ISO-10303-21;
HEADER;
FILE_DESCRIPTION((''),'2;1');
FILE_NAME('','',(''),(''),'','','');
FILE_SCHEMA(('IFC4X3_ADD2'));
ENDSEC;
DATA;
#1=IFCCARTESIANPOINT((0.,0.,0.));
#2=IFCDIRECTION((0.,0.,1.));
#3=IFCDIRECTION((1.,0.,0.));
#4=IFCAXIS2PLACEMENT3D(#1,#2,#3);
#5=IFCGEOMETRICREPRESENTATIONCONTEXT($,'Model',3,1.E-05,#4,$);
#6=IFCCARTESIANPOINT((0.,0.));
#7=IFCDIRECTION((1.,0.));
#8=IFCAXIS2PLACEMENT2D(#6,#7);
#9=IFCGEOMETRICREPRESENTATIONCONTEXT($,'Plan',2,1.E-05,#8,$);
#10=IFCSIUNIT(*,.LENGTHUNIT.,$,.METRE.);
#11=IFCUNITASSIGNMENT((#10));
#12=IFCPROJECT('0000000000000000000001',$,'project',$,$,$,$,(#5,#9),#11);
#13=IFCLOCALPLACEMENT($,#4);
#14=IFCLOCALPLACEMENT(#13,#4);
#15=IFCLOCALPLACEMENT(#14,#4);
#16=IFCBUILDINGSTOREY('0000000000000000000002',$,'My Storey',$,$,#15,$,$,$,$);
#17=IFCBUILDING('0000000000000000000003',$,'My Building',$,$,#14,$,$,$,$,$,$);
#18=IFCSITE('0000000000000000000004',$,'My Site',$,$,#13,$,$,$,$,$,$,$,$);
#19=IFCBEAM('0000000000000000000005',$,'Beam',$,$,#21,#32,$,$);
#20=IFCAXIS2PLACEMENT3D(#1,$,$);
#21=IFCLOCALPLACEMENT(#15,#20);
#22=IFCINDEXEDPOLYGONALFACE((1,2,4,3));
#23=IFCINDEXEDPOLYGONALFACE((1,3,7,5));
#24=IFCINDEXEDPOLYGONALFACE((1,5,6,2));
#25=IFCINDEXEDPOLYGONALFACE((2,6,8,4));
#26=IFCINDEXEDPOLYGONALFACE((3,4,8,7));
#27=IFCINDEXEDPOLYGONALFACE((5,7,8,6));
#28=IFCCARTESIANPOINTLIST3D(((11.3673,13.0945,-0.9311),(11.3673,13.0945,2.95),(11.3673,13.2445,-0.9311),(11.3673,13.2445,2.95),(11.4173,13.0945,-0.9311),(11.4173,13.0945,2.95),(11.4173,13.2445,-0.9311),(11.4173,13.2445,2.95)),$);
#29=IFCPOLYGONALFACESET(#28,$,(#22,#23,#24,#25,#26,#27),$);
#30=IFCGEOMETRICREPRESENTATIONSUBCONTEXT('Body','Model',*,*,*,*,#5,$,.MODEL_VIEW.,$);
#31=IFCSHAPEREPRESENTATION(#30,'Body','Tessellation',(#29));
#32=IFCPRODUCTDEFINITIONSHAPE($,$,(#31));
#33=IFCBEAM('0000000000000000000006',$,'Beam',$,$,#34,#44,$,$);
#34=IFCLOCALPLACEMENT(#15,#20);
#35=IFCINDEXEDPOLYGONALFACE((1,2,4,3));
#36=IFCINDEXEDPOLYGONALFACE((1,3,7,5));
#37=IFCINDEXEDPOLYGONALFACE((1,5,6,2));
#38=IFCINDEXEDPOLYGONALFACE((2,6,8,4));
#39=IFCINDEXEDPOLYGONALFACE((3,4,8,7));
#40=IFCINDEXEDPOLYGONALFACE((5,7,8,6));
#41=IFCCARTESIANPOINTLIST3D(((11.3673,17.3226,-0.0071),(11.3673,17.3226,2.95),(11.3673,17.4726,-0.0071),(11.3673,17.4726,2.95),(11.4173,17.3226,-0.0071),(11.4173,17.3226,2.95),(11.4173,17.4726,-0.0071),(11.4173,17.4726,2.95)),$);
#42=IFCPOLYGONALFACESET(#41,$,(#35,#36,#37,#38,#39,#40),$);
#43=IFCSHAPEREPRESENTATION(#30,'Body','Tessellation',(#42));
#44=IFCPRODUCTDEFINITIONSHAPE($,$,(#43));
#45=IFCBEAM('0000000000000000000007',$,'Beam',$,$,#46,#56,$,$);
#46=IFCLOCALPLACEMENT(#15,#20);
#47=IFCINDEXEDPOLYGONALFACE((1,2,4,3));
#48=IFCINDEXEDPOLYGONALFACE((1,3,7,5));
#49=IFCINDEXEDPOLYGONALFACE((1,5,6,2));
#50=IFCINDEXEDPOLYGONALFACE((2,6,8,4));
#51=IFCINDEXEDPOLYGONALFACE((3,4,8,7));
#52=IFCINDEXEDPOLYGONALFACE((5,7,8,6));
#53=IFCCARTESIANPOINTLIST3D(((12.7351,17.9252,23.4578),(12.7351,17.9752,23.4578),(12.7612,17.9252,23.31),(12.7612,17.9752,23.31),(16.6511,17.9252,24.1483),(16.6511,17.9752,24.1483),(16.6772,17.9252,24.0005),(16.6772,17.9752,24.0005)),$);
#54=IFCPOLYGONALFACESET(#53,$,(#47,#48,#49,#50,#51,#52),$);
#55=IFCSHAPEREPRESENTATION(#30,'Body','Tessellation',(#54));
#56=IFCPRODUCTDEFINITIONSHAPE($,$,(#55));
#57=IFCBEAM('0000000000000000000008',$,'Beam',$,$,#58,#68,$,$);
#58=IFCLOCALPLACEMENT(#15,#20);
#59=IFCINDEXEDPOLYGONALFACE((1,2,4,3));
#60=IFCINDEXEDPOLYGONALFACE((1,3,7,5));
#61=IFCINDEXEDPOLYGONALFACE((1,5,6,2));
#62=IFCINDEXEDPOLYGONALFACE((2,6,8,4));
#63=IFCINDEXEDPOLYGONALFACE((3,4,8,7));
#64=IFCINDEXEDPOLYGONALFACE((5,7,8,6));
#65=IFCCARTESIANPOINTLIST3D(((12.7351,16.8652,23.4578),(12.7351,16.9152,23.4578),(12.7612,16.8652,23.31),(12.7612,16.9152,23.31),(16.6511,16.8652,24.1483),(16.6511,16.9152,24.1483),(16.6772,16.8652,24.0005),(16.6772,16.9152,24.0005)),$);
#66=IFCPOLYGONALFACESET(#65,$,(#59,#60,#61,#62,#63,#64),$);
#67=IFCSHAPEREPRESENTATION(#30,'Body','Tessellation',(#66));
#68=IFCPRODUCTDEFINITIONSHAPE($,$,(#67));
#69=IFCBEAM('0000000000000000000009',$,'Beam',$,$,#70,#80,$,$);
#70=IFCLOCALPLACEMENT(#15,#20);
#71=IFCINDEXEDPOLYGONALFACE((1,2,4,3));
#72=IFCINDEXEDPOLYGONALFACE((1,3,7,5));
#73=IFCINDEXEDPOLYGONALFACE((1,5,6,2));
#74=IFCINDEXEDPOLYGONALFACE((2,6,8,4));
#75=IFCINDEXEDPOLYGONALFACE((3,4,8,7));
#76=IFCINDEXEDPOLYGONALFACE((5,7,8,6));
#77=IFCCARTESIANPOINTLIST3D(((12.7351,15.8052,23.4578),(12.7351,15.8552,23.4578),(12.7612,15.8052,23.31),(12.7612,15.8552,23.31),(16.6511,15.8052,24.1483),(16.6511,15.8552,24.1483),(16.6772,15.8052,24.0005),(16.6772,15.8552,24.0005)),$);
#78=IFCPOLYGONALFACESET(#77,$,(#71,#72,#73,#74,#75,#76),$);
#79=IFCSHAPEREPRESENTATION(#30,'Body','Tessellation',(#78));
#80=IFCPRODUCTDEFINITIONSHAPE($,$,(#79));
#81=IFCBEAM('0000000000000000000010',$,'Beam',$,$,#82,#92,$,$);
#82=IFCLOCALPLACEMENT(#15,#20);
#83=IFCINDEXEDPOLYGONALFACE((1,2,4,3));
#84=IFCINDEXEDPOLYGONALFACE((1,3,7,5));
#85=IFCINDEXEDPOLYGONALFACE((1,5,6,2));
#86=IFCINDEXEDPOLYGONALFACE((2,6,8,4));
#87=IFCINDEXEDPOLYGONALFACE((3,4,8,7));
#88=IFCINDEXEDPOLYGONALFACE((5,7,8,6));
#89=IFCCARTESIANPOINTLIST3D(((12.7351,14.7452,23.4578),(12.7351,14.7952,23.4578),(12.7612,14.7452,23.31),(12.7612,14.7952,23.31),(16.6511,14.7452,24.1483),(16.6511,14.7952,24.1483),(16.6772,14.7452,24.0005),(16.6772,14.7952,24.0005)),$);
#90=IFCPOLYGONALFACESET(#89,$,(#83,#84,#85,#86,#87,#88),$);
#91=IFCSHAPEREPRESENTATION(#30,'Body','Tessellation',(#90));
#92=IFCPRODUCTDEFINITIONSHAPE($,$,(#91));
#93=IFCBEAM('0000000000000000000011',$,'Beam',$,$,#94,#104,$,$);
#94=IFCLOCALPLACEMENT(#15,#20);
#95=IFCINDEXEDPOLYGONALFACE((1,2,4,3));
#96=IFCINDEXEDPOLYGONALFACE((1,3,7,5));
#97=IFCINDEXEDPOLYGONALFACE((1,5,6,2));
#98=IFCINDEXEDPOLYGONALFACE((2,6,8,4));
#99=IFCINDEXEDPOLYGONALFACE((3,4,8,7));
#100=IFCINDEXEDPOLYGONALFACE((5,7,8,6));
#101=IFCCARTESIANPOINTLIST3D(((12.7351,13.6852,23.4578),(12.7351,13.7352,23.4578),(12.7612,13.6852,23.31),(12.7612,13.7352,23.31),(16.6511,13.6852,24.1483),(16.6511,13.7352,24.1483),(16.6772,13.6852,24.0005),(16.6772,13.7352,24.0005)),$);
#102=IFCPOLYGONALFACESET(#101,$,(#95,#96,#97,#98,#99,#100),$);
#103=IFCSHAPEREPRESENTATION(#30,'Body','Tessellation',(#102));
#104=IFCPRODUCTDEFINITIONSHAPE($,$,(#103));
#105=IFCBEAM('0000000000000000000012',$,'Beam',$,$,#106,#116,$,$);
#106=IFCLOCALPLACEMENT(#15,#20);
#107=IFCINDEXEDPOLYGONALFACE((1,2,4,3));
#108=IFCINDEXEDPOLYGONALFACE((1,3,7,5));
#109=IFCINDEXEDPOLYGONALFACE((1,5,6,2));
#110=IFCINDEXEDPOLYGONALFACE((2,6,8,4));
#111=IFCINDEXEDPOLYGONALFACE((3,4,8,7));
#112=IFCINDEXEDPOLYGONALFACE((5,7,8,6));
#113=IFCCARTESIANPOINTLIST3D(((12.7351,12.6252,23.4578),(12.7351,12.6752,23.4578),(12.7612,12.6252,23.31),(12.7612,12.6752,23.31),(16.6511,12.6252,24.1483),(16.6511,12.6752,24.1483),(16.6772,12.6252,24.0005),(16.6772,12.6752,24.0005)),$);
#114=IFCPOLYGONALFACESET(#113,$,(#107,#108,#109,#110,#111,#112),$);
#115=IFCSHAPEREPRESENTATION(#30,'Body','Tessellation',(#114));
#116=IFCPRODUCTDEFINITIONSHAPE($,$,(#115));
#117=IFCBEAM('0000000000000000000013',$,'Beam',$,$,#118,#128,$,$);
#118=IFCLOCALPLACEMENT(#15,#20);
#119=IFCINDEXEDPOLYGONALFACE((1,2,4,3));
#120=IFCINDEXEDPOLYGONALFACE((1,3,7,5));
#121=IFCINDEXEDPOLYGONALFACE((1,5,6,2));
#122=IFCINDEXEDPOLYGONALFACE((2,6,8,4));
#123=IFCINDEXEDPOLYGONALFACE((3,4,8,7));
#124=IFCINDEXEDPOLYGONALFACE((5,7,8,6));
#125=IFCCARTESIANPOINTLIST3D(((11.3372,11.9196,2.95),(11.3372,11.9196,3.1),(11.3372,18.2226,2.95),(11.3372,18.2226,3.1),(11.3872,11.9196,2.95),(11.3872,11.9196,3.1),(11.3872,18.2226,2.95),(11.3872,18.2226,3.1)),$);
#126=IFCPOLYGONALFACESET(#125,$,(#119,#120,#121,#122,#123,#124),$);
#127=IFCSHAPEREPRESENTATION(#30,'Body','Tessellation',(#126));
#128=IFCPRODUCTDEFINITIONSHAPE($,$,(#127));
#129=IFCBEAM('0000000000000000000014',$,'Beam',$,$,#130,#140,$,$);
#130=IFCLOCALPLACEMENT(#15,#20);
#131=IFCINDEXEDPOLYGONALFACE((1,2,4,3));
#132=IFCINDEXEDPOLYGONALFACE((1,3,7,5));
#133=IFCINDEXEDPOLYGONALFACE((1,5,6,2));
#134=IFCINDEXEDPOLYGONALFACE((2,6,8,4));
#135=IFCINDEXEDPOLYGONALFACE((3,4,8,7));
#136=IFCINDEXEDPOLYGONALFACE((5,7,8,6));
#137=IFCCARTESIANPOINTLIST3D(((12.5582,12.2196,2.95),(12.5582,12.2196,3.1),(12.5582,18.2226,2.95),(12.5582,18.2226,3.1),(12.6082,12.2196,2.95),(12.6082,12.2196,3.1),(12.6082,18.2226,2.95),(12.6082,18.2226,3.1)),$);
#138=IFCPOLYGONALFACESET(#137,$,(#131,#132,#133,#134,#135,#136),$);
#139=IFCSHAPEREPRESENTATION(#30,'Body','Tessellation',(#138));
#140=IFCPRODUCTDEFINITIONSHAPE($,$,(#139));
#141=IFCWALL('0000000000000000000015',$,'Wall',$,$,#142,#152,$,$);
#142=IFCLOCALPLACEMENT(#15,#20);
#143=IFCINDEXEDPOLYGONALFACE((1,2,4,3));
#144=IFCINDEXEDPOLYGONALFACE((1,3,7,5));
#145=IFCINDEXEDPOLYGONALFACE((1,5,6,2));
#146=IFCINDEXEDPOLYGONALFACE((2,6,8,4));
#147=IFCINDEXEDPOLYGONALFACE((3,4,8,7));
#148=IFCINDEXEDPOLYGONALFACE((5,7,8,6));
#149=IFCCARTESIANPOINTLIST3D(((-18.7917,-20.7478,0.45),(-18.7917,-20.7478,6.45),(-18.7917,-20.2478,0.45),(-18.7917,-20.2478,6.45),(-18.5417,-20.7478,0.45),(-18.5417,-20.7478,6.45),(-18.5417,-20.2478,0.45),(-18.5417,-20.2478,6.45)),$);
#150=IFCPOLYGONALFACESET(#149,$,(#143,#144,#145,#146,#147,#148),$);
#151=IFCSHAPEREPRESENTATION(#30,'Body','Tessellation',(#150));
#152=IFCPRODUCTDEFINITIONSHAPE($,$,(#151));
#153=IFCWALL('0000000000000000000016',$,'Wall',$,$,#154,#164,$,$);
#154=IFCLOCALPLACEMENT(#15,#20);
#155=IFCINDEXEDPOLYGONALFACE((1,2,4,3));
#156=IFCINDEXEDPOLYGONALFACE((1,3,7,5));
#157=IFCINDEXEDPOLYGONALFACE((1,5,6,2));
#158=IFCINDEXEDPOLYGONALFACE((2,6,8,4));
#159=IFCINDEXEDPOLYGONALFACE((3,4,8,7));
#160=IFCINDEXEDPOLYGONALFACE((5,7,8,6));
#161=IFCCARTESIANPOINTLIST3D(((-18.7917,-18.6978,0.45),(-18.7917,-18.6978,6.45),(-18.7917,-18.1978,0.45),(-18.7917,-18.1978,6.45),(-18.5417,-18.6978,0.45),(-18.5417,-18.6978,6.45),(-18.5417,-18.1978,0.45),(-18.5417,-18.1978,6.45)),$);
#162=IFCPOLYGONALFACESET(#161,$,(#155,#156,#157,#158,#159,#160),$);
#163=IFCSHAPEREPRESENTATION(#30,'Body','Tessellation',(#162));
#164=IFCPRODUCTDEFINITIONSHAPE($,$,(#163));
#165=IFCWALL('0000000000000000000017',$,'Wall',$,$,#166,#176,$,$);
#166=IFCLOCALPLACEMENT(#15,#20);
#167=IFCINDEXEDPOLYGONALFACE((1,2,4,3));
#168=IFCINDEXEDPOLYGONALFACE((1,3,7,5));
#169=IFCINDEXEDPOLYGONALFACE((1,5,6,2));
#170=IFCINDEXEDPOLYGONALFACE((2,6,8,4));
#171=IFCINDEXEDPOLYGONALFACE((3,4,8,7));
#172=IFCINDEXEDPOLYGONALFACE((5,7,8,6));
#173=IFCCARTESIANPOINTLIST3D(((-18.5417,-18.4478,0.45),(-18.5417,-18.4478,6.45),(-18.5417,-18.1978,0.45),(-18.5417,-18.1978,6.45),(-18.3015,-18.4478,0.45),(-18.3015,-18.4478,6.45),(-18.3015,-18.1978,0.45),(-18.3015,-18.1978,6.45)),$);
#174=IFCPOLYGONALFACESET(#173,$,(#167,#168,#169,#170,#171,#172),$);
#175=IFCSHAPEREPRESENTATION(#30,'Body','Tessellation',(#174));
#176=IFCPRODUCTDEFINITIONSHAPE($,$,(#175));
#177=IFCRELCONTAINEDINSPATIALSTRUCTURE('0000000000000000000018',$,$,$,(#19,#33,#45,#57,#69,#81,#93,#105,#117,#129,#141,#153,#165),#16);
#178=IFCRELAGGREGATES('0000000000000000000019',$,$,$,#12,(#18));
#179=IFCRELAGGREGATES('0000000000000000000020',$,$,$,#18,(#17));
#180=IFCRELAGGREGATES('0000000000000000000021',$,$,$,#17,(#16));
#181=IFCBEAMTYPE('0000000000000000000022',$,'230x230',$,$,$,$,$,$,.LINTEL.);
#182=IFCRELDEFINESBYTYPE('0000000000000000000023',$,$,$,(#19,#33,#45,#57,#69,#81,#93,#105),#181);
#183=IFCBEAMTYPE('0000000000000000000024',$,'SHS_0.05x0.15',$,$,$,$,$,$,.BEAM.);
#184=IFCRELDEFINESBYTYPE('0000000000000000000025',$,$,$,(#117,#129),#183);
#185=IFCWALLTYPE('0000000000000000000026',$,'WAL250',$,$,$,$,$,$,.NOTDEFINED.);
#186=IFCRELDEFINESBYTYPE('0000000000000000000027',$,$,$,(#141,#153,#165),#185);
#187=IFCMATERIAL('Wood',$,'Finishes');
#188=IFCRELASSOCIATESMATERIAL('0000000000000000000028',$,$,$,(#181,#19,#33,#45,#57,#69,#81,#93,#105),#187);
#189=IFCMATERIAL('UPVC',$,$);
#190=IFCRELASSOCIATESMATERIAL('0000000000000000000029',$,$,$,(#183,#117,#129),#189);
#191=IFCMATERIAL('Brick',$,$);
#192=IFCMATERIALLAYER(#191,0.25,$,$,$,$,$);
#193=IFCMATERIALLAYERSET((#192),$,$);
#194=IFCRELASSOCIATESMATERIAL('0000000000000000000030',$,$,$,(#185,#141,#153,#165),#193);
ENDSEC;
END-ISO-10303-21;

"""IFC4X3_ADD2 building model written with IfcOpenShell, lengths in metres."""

from ifc_helpers import new_model, si_unit, frame, origin_with_axes, origin_2d_with_axis, place, context, subcontext, project, spatial, line, indexed_curve, outline, extrude, material, layer, layer_set, layer_usage, material_profile, profile_set, profile_usage, type_object, element, save


model = new_model("IFC4X3_ADD2")

# Units and contexts
model_context = context("Model", 3, precision=1e-05, world=origin_with_axes())
plan_context = context("Plan", 2, precision=1e-05, world=origin_2d_with_axis())
body_context = subcontext(model_context, "Body", "Model", "MODEL_VIEW")
ifc_project = project(units=[si_unit("LENGTHUNIT", "METRE")], contexts=[model_context, plan_context])

# Site, building, storey
site_placement = place(None, origin_with_axes())
site = spatial("IfcSite", under=ifc_project, at=site_placement, Name="My Site")
building_placement = place(site_placement, origin_with_axes())
building = spatial("IfcBuilding", under=site, at=building_placement, Name="My Building")
storey_placement = place(building_placement, origin_with_axes())
storey = spatial("IfcBuildingStorey", under=building, at=storey_placement, Name="My Storey")

# Beams
ifc_material_1 = material(Name="Wood", Category="Finishes")
ifc_material_profile_1 = material_profile(ifc_material_1, outline(indexed_curve([(-0.025, 0.075), (0.025, 0.075), (0.025, -0.075), (-0.025, -0.075), (-0.025, 0.075)])))
ifc_profile_set_1 = profile_set([ifc_material_profile_1])
ifc_profile_usage_1 = profile_usage(ifc_profile_set_1, cardinal=5)
beam_type_1 = type_object("IfcBeamType", Name="230x230", PredefinedType="LINTEL", material=ifc_profile_set_1)
beam_1_placement = place(storey_placement, frame((11.3923, 13.1695, -0.9311), z_axis=(0.0, 0.0, 1.0), x_axis=(-1.0, 0.0, 0.0)))
element("IfcBeam", 1, at=beam_1_placement, inside=storey, type_object=beam_type_1, material=ifc_profile_usage_1, Name="Beam", context=body_context, shape_type="SweptSolid", body=[
    extrude(outline(indexed_curve([(-0.025, 0.075), (0.025, 0.075), (0.025, -0.075), (-0.025, -0.075), (-0.025, 0.075)])), origin_with_axes(), (0.0, 0.0, 1.0), 3.8811),
])
ifc_profile_usage_2 = profile_usage(ifc_profile_set_1, cardinal=5)
beam_2_placement = place(storey_placement, frame((11.3923, 17.3976, -0.0071), z_axis=(0.0, 0.0, 1.0), x_axis=(-1.0, 0.0, 0.0)))
element("IfcBeam", 2, at=beam_2_placement, inside=storey, type_object=beam_type_1, material=ifc_profile_usage_2, Name="Beam", context=body_context, shape_type="SweptSolid", body=[
    extrude(outline(indexed_curve([(-0.025, 0.075), (0.025, 0.075), (0.025, -0.075), (-0.025, -0.075), (-0.025, 0.075)])), origin_with_axes(), (0.0, 0.0, 1.0), 2.9571),
])
ifc_profile_usage_3 = profile_usage(ifc_profile_set_1, cardinal=5)
beam_3_placement = place(storey_placement, frame((12.7481, 17.9502, 23.3839), z_axis=(0.984808, 0.0, 0.173648), x_axis=(0.0, -1.0, 0.0)))
element("IfcBeam", 3, at=beam_3_placement, inside=storey, type_object=beam_type_1, material=ifc_profile_usage_3, Name="Beam", context=body_context, shape_type="SweptSolid", body=[
    extrude(outline(indexed_curve([(-0.025, 0.075), (0.025, 0.075), (0.025, -0.075), (-0.025, -0.075), (-0.025, 0.075)])), origin_with_axes(), (0.0, 0.0, 1.0), 3.9764),
])
ifc_profile_usage_4 = profile_usage(ifc_profile_set_1, cardinal=5)
beam_4_placement = place(storey_placement, frame((12.7481, 16.8902, 23.3839), z_axis=(0.984808, 0.0, 0.173648), x_axis=(0.0, -1.0, 0.0)))
element("IfcBeam", 4, at=beam_4_placement, inside=storey, type_object=beam_type_1, material=ifc_profile_usage_4, Name="Beam", context=body_context, shape_type="SweptSolid", body=[
    extrude(outline(indexed_curve([(-0.025, 0.075), (0.025, 0.075), (0.025, -0.075), (-0.025, -0.075), (-0.025, 0.075)])), origin_with_axes(), (0.0, 0.0, 1.0), 3.9764),
])
ifc_profile_usage_5 = profile_usage(ifc_profile_set_1, cardinal=5)
beam_5_placement = place(storey_placement, frame((12.7481, 15.8302, 23.3839), z_axis=(0.984808, 0.0, 0.173648), x_axis=(0.0, -1.0, 0.0)))
element("IfcBeam", 5, at=beam_5_placement, inside=storey, type_object=beam_type_1, material=ifc_profile_usage_5, Name="Beam", context=body_context, shape_type="SweptSolid", body=[
    extrude(outline(indexed_curve([(-0.025, 0.075), (0.025, 0.075), (0.025, -0.075), (-0.025, -0.075), (-0.025, 0.075)])), origin_with_axes(), (0.0, 0.0, 1.0), 3.9764),
])
ifc_profile_usage_6 = profile_usage(ifc_profile_set_1, cardinal=5)
beam_6_placement = place(storey_placement, frame((12.7481, 14.7702, 23.3839), z_axis=(0.984808, 0.0, 0.173648), x_axis=(0.0, -1.0, 0.0)))
element("IfcBeam", 6, at=beam_6_placement, inside=storey, type_object=beam_type_1, material=ifc_profile_usage_6, Name="Beam", context=body_context, shape_type="SweptSolid", body=[
    extrude(outline(indexed_curve([(-0.025, 0.075), (0.025, 0.075), (0.025, -0.075), (-0.025, -0.075), (-0.025, 0.075)])), origin_with_axes(), (0.0, 0.0, 1.0), 3.9764),
])
ifc_profile_usage_7 = profile_usage(ifc_profile_set_1, cardinal=5)
beam_7_placement = place(storey_placement, frame((12.7481, 13.7102, 23.3839), z_axis=(0.984808, 0.0, 0.173648), x_axis=(0.0, -1.0, 0.0)))
element("IfcBeam", 7, at=beam_7_placement, inside=storey, type_object=beam_type_1, material=ifc_profile_usage_7, Name="Beam", context=body_context, shape_type="SweptSolid", body=[
    extrude(outline(indexed_curve([(-0.025, 0.075), (0.025, 0.075), (0.025, -0.075), (-0.025, -0.075), (-0.025, 0.075)])), origin_with_axes(), (0.0, 0.0, 1.0), 3.9764),
])
ifc_profile_usage_8 = profile_usage(ifc_profile_set_1, cardinal=5)
beam_8_placement = place(storey_placement, frame((12.7481, 12.6502, 23.3839), z_axis=(0.984808, 0.0, 0.173648), x_axis=(0.0, -1.0, 0.0)))
element("IfcBeam", 8, at=beam_8_placement, inside=storey, type_object=beam_type_1, material=ifc_profile_usage_8, Name="Beam", context=body_context, shape_type="SweptSolid", body=[
    extrude(outline(indexed_curve([(-0.025, 0.075), (0.025, 0.075), (0.025, -0.075), (-0.025, -0.075), (-0.025, 0.075)])), origin_with_axes(), (0.0, 0.0, 1.0), 3.9764),
])
ifc_material_2 = material(Name="UPVC")
ifc_material_profile_2 = material_profile(ifc_material_2, outline(indexed_curve([(-0.025, 0.075), (0.025, 0.075), (0.025, -0.075), (-0.025, -0.075), (-0.025, 0.075)])))
ifc_profile_set_2 = profile_set([ifc_material_profile_2])
ifc_profile_usage_9 = profile_usage(ifc_profile_set_2, cardinal=5)
beam_type_2 = type_object("IfcBeamType", Name="SHS_0.05x0.15", PredefinedType="BEAM", material=ifc_profile_set_2)
beam_9_placement = place(storey_placement, frame((11.3622, 18.2226, 3.025), z_axis=(0.0, -1.0, 0.0), x_axis=(1.0, 0.0, 0.0)))
element("IfcBeam", 9, at=beam_9_placement, inside=storey, type_object=beam_type_2, material=ifc_profile_usage_9, Name="Beam", context=body_context, shape_type="SweptSolid", body=[
    extrude(outline(indexed_curve([(-0.025, 0.075), (0.025, 0.075), (0.025, -0.075), (-0.025, -0.075), (-0.025, 0.075)])), origin_with_axes(), (0.0, 0.0, 1.0), 6.3031),
])
ifc_profile_usage_10 = profile_usage(ifc_profile_set_2, cardinal=5)
beam_10_placement = place(storey_placement, frame((12.5832, 18.2226, 3.025), z_axis=(0.0, -1.0, 0.0), x_axis=(1.0, 0.0, 0.0)))
element("IfcBeam", 10, at=beam_10_placement, inside=storey, type_object=beam_type_2, material=ifc_profile_usage_10, Name="Beam", context=body_context, shape_type="SweptSolid", body=[
    extrude(outline(indexed_curve([(-0.025, 0.075), (0.025, 0.075), (0.025, -0.075), (-0.025, -0.075), (-0.025, 0.075)])), origin_with_axes(), (0.0, 0.0, 1.0), 6.003),
])

# Shared definitions
ifc_material_3 = material(Name="Brick")

# Walls
ifc_layer_1 = layer(ifc_material_3, 0.25)
ifc_layer_set_1 = layer_set([ifc_layer_1])
ifc_layer_usage_1 = layer_usage(ifc_layer_set_1, "AXIS2", "NEGATIVE", 0.0)
wall_type = type_object("IfcWallType", Name="WAL250", PredefinedType="NOTDEFINED", material=ifc_layer_set_1)
wall_1_placement = place(storey_placement, frame((-18.7917, -20.7478, 0.45), z_axis=(0.0, 0.0, 1.0), x_axis=(0.0, 1.0, 0.0)))
element("IfcWall", 11, at=wall_1_placement, inside=storey, type_object=wall_type, material=ifc_layer_usage_1, Name="Wall", context=body_context, shape_type="SweptSolid", body=[
    extrude(outline(indexed_curve([(0.0, -0.25), (0.0, 0.0), (0.5, 0.0), (0.5, -0.25)], segments=[line(1, 2, 3, 4, 1)])), origin_with_axes(), (0.0, 0.0, 1.0), 6.0),
])
ifc_layer_usage_2 = layer_usage(ifc_layer_set_1, "AXIS2", "NEGATIVE", 0.0)
wall_2_placement = place(storey_placement, frame((-18.7917, -18.6978, 0.45), z_axis=(0.0, 0.0, 1.0), x_axis=(0.000001, 1.0, 0.0)))
element("IfcWall", 12, at=wall_2_placement, inside=storey, type_object=wall_type, material=ifc_layer_usage_2, Name="Wall", context=body_context, shape_type="SweptSolid", body=[
    extrude(outline(indexed_curve([(0.0, -0.25), (0.0, 0.0), (0.5, 0.0), (0.5, -0.25)], segments=[line(1, 2, 3, 4, 1)])), origin_with_axes(), (0.0, 0.0, 1.0), 6.0),
])
ifc_layer_usage_3 = layer_usage(ifc_layer_set_1, "AXIS2", "NEGATIVE", 0.0)
wall_3_placement = place(storey_placement, frame((-18.3015, -18.4478, 0.45), z_axis=(0.0, 0.0, 1.0), x_axis=(-1.0, 0.000001, 0.0)))
element("IfcWall", 13, at=wall_3_placement, inside=storey, type_object=wall_type, material=ifc_layer_usage_3, Name="Wall", context=body_context, shape_type="SweptSolid", body=[
    extrude(outline(indexed_curve([(0.0, -0.25), (0.0, 0.0), (0.2402, 0.0), (0.2402, -0.25)], segments=[line(1, 2, 3, 4, 1)])), origin_with_axes(), (0.0, 0.0, 1.0), 6.0),
])

save(model, "model.ifc")
